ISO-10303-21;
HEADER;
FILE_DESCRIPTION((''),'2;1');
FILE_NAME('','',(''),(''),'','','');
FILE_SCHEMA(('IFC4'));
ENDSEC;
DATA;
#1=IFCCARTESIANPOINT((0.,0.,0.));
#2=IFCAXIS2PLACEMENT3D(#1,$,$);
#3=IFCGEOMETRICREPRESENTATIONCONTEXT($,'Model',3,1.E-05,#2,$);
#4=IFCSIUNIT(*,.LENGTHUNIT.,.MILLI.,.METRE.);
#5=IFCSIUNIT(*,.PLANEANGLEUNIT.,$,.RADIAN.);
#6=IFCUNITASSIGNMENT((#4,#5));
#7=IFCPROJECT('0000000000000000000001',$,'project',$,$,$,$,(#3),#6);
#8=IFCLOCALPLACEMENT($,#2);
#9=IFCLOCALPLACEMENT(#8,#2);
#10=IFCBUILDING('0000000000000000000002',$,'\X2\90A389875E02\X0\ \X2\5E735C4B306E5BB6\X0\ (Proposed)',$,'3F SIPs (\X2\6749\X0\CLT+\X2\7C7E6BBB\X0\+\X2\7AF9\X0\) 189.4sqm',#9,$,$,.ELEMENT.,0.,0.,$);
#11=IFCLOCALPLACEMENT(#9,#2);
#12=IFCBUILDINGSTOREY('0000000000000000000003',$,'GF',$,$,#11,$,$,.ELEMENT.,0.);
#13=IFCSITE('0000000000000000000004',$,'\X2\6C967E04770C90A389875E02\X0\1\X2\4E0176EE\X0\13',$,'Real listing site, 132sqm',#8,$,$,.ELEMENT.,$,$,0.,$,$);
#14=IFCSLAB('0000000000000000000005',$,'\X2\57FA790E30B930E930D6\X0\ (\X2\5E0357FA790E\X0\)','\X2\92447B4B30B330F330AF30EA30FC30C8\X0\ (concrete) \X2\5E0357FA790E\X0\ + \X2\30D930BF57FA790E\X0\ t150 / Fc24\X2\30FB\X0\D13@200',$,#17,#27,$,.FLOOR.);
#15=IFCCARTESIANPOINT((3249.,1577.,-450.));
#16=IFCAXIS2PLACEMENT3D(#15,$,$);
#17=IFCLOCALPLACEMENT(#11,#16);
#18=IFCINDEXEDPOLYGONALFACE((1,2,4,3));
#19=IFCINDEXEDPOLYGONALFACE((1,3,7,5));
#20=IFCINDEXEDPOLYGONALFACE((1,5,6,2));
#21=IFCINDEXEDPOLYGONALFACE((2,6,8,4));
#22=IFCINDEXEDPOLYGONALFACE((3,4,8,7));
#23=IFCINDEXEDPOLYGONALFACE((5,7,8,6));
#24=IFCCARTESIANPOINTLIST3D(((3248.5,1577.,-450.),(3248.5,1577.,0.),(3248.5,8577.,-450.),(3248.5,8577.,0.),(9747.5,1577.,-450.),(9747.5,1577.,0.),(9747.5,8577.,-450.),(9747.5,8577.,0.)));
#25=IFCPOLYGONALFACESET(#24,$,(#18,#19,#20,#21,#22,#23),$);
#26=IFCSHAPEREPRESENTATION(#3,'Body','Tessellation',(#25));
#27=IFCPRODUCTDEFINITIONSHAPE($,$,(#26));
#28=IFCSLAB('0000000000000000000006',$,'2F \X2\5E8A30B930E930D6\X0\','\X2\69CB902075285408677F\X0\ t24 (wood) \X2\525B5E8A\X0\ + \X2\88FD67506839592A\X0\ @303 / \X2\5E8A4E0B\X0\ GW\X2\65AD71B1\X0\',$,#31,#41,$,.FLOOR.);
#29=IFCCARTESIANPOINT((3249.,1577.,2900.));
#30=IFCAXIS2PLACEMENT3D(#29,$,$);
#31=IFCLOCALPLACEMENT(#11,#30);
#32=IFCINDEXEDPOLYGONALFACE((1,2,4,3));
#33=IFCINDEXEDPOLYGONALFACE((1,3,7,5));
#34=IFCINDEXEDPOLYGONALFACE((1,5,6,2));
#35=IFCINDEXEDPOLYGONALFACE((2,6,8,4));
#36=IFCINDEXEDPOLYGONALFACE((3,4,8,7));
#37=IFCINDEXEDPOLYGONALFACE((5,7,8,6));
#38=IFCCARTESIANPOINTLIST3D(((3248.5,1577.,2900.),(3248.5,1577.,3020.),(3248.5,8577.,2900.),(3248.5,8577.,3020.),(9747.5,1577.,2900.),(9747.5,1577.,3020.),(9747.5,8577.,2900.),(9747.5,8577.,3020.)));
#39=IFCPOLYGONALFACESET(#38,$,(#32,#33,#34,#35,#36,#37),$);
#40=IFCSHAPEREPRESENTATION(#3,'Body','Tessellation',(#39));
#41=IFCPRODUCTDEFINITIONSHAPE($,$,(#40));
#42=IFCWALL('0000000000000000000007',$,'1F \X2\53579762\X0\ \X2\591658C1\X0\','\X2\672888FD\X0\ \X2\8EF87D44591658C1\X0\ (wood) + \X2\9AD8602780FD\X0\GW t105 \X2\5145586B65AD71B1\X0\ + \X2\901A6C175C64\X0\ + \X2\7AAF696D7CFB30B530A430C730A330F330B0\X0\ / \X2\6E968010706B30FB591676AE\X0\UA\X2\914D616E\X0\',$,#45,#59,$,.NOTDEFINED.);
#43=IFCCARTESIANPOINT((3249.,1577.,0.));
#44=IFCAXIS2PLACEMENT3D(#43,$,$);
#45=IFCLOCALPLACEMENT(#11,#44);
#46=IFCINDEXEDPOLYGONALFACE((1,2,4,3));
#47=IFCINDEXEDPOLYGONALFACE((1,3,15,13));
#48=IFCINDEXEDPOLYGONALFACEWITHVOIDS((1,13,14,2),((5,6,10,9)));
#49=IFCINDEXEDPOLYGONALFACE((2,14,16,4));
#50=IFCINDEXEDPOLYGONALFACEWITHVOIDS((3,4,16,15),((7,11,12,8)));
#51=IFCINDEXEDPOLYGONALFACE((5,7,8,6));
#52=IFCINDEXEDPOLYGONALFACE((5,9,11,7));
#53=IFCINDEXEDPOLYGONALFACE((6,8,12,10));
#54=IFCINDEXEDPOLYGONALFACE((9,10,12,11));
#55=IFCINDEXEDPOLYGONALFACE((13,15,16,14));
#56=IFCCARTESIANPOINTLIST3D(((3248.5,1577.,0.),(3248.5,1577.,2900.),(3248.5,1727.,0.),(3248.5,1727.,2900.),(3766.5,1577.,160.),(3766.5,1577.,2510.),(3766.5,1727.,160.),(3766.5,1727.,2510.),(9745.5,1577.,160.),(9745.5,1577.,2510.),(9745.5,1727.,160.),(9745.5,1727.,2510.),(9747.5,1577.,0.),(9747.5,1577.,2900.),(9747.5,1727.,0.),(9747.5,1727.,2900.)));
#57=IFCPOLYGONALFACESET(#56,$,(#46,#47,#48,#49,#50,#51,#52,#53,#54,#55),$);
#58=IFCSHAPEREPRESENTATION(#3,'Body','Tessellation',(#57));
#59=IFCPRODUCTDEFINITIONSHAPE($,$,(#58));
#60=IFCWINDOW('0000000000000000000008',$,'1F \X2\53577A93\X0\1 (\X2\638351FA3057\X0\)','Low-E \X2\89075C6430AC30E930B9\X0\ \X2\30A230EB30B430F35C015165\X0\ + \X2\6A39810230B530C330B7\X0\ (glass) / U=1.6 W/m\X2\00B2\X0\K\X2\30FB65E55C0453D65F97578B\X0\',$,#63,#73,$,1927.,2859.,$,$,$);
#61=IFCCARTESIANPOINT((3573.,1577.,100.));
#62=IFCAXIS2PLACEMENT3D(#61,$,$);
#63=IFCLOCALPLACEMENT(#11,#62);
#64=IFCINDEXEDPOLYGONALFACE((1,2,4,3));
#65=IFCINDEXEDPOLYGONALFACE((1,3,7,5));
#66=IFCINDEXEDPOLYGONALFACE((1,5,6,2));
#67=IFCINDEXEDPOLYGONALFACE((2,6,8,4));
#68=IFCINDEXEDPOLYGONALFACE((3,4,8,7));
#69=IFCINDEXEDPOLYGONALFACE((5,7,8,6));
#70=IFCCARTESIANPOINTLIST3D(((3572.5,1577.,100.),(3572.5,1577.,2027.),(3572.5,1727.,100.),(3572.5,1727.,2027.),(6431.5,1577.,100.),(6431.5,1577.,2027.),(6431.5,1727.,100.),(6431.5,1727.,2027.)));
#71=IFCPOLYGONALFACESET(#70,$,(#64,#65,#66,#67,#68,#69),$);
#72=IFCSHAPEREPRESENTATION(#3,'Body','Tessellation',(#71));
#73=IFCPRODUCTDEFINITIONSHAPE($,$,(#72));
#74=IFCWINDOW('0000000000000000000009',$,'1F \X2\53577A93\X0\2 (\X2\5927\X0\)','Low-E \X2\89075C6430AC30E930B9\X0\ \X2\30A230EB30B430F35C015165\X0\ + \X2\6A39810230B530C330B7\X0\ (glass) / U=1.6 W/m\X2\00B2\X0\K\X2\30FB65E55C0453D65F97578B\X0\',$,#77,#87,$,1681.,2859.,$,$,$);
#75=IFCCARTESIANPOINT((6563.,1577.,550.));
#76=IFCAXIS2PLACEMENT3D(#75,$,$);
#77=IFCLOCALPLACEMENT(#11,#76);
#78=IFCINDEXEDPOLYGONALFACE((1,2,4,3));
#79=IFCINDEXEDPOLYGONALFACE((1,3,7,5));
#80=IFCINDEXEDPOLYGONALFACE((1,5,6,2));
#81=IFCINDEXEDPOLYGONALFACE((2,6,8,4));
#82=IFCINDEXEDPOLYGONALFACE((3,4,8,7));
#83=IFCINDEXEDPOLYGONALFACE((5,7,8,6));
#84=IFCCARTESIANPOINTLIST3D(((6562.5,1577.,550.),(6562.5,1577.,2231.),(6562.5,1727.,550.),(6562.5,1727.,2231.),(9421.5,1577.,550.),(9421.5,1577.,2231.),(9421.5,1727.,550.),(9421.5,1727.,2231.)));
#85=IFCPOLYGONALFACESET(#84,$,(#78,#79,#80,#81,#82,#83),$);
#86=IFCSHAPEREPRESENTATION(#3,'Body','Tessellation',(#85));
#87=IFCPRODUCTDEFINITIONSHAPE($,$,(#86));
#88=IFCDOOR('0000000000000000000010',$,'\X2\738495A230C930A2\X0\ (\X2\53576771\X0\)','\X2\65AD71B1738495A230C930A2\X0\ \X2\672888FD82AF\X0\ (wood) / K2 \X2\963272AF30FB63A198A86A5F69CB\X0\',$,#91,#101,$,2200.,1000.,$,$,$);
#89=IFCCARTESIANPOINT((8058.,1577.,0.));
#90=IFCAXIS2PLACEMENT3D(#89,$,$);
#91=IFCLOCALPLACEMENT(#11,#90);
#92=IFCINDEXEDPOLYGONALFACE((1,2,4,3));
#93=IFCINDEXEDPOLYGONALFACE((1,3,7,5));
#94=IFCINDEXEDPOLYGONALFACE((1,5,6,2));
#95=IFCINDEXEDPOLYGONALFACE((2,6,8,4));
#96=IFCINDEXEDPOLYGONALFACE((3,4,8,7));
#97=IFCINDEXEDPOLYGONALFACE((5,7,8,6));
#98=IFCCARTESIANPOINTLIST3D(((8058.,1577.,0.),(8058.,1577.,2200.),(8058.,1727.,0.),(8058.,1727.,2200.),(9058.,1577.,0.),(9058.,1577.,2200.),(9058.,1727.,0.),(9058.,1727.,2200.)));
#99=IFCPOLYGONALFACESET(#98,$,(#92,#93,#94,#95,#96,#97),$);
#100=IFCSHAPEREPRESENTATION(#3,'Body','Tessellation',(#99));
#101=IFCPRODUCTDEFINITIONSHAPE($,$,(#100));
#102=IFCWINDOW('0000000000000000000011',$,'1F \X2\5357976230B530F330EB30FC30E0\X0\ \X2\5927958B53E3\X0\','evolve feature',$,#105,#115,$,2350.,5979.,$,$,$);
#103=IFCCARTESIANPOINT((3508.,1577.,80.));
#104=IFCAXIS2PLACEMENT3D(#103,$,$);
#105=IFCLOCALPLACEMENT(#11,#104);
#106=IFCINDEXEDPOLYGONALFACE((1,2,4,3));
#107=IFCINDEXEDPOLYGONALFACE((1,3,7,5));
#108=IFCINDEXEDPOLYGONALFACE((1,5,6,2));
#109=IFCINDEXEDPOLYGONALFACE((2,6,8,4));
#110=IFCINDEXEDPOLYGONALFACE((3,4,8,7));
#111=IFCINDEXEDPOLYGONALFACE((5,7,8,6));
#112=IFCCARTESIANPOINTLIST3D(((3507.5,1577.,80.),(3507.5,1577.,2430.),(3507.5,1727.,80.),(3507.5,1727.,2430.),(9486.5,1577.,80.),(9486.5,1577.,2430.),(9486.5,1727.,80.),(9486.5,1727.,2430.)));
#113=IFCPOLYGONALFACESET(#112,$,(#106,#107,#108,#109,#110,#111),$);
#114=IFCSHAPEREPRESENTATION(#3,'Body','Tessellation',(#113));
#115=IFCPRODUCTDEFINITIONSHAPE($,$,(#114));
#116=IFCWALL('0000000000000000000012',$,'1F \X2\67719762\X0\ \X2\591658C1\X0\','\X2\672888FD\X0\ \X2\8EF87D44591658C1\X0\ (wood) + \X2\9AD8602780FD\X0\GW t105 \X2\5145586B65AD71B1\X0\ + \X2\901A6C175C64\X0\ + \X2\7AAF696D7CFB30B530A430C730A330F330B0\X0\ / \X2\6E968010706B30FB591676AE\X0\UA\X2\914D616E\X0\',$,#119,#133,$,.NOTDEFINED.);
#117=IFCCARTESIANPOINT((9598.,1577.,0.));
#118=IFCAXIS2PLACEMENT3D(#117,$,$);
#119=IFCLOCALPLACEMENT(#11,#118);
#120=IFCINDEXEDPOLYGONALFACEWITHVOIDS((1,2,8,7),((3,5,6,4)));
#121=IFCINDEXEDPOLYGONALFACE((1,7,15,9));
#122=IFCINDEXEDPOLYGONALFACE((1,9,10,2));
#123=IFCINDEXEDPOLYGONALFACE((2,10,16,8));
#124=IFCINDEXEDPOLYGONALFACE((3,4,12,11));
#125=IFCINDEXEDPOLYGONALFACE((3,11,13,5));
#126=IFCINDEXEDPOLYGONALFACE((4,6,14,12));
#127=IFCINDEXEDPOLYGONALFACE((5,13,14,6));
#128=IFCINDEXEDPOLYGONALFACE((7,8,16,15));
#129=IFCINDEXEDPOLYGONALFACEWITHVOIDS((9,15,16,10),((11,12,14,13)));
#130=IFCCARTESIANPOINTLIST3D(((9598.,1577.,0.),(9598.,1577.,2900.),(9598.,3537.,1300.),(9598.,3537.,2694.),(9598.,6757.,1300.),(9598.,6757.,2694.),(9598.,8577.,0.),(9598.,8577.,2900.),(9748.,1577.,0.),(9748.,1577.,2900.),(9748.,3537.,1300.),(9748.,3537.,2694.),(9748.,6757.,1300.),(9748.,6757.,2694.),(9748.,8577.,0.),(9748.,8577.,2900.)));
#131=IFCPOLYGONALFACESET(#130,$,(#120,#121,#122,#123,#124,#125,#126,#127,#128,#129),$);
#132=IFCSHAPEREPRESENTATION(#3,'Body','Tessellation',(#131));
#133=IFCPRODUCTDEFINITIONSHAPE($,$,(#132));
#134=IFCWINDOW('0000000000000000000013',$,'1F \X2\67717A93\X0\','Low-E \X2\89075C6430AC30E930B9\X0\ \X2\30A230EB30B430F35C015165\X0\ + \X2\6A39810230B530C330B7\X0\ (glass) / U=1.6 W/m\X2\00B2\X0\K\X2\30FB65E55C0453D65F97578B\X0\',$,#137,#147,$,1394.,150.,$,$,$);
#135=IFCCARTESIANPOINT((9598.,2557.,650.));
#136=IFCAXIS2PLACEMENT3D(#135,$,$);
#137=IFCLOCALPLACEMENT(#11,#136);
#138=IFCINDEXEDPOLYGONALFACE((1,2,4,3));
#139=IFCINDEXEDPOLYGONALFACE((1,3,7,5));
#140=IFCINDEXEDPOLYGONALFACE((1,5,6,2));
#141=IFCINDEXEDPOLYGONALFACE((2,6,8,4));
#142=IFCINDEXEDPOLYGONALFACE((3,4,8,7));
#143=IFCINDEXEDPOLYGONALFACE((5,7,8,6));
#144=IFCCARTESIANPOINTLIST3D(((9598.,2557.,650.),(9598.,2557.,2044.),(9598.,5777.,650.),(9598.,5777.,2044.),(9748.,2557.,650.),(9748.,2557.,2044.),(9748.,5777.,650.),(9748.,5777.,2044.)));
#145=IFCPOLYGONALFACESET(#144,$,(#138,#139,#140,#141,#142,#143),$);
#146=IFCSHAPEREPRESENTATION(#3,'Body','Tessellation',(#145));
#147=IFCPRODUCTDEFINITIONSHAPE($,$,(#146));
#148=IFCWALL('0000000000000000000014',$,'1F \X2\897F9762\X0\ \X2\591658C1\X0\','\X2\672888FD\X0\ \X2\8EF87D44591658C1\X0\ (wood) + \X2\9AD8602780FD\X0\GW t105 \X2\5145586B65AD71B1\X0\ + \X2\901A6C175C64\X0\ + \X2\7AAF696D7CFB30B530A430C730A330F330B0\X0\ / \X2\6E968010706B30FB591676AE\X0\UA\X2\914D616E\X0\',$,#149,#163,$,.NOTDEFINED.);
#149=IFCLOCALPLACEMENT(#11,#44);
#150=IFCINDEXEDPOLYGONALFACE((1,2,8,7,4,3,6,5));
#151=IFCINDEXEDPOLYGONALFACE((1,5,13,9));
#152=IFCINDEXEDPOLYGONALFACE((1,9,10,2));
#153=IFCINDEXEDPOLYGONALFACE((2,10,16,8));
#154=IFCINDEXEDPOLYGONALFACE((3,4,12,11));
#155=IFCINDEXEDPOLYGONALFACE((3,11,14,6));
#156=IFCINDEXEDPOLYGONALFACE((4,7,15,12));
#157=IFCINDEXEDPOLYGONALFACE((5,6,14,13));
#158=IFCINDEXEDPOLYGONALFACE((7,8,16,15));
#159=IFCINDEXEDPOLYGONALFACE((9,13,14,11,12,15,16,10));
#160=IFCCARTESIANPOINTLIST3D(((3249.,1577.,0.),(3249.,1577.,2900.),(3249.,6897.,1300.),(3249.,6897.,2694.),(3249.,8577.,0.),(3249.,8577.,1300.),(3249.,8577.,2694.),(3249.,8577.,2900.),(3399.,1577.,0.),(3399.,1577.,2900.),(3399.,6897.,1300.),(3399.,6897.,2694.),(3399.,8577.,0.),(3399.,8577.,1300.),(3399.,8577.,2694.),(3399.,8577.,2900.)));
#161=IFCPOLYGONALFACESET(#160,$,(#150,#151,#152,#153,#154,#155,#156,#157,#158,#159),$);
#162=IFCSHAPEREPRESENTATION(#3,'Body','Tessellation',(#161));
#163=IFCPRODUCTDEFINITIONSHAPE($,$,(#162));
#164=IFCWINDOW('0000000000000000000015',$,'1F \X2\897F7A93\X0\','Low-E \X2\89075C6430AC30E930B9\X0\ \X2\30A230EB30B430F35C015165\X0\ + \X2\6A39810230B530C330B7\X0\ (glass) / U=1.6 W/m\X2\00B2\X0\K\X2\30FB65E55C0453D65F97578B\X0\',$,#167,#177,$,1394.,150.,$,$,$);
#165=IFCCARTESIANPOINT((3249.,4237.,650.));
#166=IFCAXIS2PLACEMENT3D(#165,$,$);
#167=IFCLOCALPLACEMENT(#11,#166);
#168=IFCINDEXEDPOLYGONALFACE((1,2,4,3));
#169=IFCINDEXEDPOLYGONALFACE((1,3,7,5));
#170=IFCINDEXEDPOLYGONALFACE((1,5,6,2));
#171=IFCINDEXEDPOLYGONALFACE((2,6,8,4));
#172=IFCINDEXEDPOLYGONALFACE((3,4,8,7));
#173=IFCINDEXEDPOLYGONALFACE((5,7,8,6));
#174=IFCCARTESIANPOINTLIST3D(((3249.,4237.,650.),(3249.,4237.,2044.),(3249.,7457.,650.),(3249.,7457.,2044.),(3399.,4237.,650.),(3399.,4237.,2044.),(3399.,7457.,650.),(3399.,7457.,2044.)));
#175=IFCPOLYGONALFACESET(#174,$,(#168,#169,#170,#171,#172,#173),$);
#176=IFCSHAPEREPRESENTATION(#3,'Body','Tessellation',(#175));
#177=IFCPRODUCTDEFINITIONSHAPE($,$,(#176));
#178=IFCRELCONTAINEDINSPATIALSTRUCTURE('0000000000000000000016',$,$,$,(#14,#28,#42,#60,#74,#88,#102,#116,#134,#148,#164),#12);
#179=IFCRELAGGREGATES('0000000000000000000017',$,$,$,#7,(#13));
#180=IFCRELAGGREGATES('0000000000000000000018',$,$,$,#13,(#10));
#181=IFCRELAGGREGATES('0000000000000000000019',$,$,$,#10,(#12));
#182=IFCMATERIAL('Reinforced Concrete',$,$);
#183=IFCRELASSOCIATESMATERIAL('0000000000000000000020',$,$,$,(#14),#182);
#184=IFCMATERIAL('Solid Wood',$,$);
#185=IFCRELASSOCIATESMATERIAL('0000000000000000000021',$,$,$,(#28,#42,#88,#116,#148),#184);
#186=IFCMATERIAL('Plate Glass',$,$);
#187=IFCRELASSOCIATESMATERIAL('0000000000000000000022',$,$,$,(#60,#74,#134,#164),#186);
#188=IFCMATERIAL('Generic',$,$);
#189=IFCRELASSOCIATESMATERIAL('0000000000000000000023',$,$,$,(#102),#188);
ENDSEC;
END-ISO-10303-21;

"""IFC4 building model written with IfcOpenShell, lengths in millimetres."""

from ifc_helpers import new_model, si_unit, frame, frame_2d, origin, place, context, project, spatial, rectangle, extrude, material, element, fill, save


model = new_model("IFC4")

# Units and contexts
model_context = context("Model", 3, precision=1e-05, world=origin())
ifc_project = project(units=[si_unit("LENGTHUNIT", "METRE", prefix="MILLI"), si_unit("PLANEANGLEUNIT", "RADIAN")], contexts=[model_context])

# Site, building, storey
site_placement = place(None, origin())
site = spatial("IfcSite", under=ifc_project, at=site_placement, Name="沖縄県那覇市1丁目13", ObjectType="Real listing site, 132sqm", CompositionType="ELEMENT", RefElevation=0.0)
building_placement = place(site_placement, origin())
building = spatial("IfcBuilding", under=site, at=building_placement, Name="那覇市 平屋の家 (Proposed)", ObjectType="3F SIPs (杉CLT+籾殻+竹) 189.4sqm", CompositionType="ELEMENT", ElevationOfRefHeight=0.0, ElevationOfTerrain=0.0)
storey_placement = place(building_placement, origin())
storey = spatial("IfcBuildingStorey", under=building, at=storey_placement, Name="GF", CompositionType="ELEMENT", Elevation=0.0)

# Slabs
ifc_material_1 = material(Name="Reinforced Concrete")
slab_1_placement = place(storey_placement, frame((3249.0, 1577.0, -450.0)))
element("IfcSlab", 1, at=slab_1_placement, inside=storey, material=ifc_material_1, Name="基礎スラブ (布基礎)", Description="鉄筋コンクリート (concrete) 布基礎 + ベタ基礎 t150 / Fc24・D13@200", PredefinedType="FLOOR", context=model_context, shape_type="SweptSolid", body=[
    extrude(rectangle(XDim=6499.0, YDim=7000.0, at=frame_2d((3249.0, 3500.0))), frame((3249.0, 1577.0, -450.0)), (0.0, 0.0, 1.0), 450.0),
])
ifc_material_2 = material(Name="Solid Wood")
slab_2_placement = place(storey_placement, frame((3249.0, 1577.0, 2900.0)))
element("IfcSlab", 2, at=slab_2_placement, inside=storey, material=ifc_material_2, Name="2F 床スラブ", Description="構造用合板 t24 (wood) 剛床 + 製材根太 @303 / 床下 GW断熱", PredefinedType="FLOOR", context=model_context, shape_type="SweptSolid", body=[
    extrude(rectangle(XDim=6499.0, YDim=7000.0, at=frame_2d((3249.0, 3500.0))), frame((3249.0, 1577.0, 2900.0)), (0.0, 0.0, 1.0), 120.0),
])

# Wall, openings, windows, door
wall_1_placement = place(storey_placement, frame((3249.0, 1577.0, 0.0)))
wall_1 = element("IfcWall", 3, at=wall_1_placement, inside=storey, material=ifc_material_2, Name="1F 南面 外壁", Description="木製 軸組外壁 (wood) + 高性能GW t105 充填断熱 + 通気層 + 窯業系サイディング / 準耐火・外皮UA配慮", PredefinedType="NOTDEFINED", context=model_context, shape_type="SweptSolid", body=[
    extrude(rectangle(XDim=6499.0, YDim=150.0, at=frame_2d((3249.0, 75.0))), frame((3249.0, 1577.0, 0.0)), (0.0, 0.0, 1.0), 2900.0),
])
opening_1_placement = place(storey_placement, frame((3573.0, 1577.0, 100.0)))
opening_1 = element("IfcOpeningElement", 4, at=opening_1_placement, cuts=wall_1, PredefinedType="NOTDEFINED", context=model_context, shape_type="SweptSolid", body=[
    extrude(rectangle(XDim=2859.0, YDim=150.0, at=frame_2d((1429.0, 75.0))), frame((3573.0, 1577.0, 100.0)), (0.0, 0.0, 1.0), 1927.0),
])
opening_2_placement = place(storey_placement, frame((6563.0, 1577.0, 550.0)))
opening_2 = element("IfcOpeningElement", 5, at=opening_2_placement, cuts=wall_1, PredefinedType="NOTDEFINED", context=model_context, shape_type="SweptSolid", body=[
    extrude(rectangle(XDim=2859.0, YDim=150.0, at=frame_2d((1429.0, 75.0))), frame((6563.0, 1577.0, 550.0)), (0.0, 0.0, 1.0), 1681.0),
])
opening_3_placement = place(storey_placement, frame((8058.0, 1577.0, 0.0)))
opening_3 = element("IfcOpeningElement", 6, at=opening_3_placement, cuts=wall_1, PredefinedType="NOTDEFINED", context=model_context, shape_type="SweptSolid", body=[
    extrude(rectangle(XDim=1000.0, YDim=150.0, at=frame_2d((500.0, 75.0))), frame((8058.0, 1577.0, 0.0)), (0.0, 0.0, 1.0), 2200.0),
])
opening_4_placement = place(storey_placement, frame((3508.0, 1577.0, 80.0)))
opening_4 = element("IfcOpeningElement", 7, at=opening_4_placement, cuts=wall_1, PredefinedType="NOTDEFINED", context=model_context, shape_type="SweptSolid", body=[
    extrude(rectangle(XDim=5979.0, YDim=150.0, at=frame_2d((2989.0, 75.0))), frame((3508.0, 1577.0, 80.0)), (0.0, 0.0, 1.0), 2350.0),
])
ifc_material_3 = material(Name="Plate Glass")
window_1_placement = place(storey_placement, frame((3573.0, 1577.0, 100.0)))
window_1 = element("IfcWindow", 8, at=window_1_placement, inside=storey, material=ifc_material_3, Name="1F 南窓1 (掃出し)", Description="Low-E 複層ガラス アルゴン封入 + 樹脂サッシ (glass) / U=1.6 W/m²K・日射取得型", OverallHeight=1927.0, OverallWidth=2859.0, context=model_context, shape_type="SweptSolid", body=[
    extrude(rectangle(XDim=2859.0, YDim=150.0, at=frame_2d((1429.0, 75.0))), frame((3573.0, 1577.0, 100.0)), (0.0, 0.0, 1.0), 1927.0),
])
fill(opening_1, window_1)
window_2_placement = place(storey_placement, frame((6563.0, 1577.0, 550.0)))
window_2 = element("IfcWindow", 9, at=window_2_placement, inside=storey, material=ifc_material_3, Name="1F 南窓2 (大)", Description="Low-E 複層ガラス アルゴン封入 + 樹脂サッシ (glass) / U=1.6 W/m²K・日射取得型", OverallHeight=1681.0, OverallWidth=2859.0, context=model_context, shape_type="SweptSolid", body=[
    extrude(rectangle(XDim=2859.0, YDim=150.0, at=frame_2d((1429.0, 75.0))), frame((6563.0, 1577.0, 550.0)), (0.0, 0.0, 1.0), 1681.0),
])
fill(opening_2, window_2)
door_placement = place(storey_placement, frame((8058.0, 1577.0, 0.0)))
door = element("IfcDoor", 10, at=door_placement, inside=storey, material=ifc_material_2, Name="玄関ドア (南東)", Description="断熱玄関ドア 木製芯 (wood) / K2 防犯・採風機構", OverallHeight=2200.0, OverallWidth=1000.0, context=model_context, shape_type="SweptSolid", body=[
    extrude(rectangle(XDim=1000.0, YDim=150.0, at=frame_2d((500.0, 75.0))), frame((8058.0, 1577.0, 0.0)), (0.0, 0.0, 1.0), 2200.0),
])
fill(opening_3, door)
ifc_material_4 = material(Name="Generic")
window_3_placement = place(storey_placement, frame((3508.0, 1577.0, 80.0)))
window_3 = element("IfcWindow", 11, at=window_3_placement, inside=storey, material=ifc_material_4, Name="1F 南面サンルーム 大開口", Description="evolve feature", OverallHeight=2350.0, OverallWidth=5979.0, context=model_context, shape_type="SweptSolid", body=[
    extrude(rectangle(XDim=5979.0, YDim=150.0, at=frame_2d((2989.0, 75.0))), frame((3508.0, 1577.0, 80.0)), (0.0, 0.0, 1.0), 2350.0),
])
fill(opening_4, window_3)

# Walls, openings, windows
wall_2_placement = place(storey_placement, frame((9598.0, 1577.0, 0.0)))
wall_2 = element("IfcWall", 12, at=wall_2_placement, inside=storey, material=ifc_material_2, Name="1F 東面 外壁", Description="木製 軸組外壁 (wood) + 高性能GW t105 充填断熱 + 通気層 + 窯業系サイディング / 準耐火・外皮UA配慮", PredefinedType="NOTDEFINED", context=model_context, shape_type="SweptSolid", body=[
    extrude(rectangle(XDim=150.0, YDim=7000.0, at=frame_2d((75.0, 3500.0))), frame((9598.0, 1577.0, 0.0)), (0.0, 0.0, 1.0), 2900.0),
])
opening_5_placement = place(storey_placement, frame((9598.0, 2557.0, 650.0)))
opening_5 = element("IfcOpeningElement", 13, at=opening_5_placement, cuts=wall_2, PredefinedType="NOTDEFINED", context=model_context, shape_type="SweptSolid", body=[
    extrude(rectangle(XDim=150.0, YDim=3220.0, at=frame_2d((75.0, 1610.0))), frame((9598.0, 2557.0, 650.0)), (0.0, 0.0, 1.0), 1394.0),
])
window_4_placement = place(storey_placement, frame((9598.0, 2557.0, 650.0)))
window_4 = element("IfcWindow", 14, at=window_4_placement, inside=storey, material=ifc_material_3, Name="1F 東窓", Description="Low-E 複層ガラス アルゴン封入 + 樹脂サッシ (glass) / U=1.6 W/m²K・日射取得型", OverallHeight=1394.0, OverallWidth=150.0, context=model_context, shape_type="SweptSolid", body=[
    extrude(rectangle(XDim=150.0, YDim=3220.0, at=frame_2d((75.0, 1610.0))), frame((9598.0, 2557.0, 650.0)), (0.0, 0.0, 1.0), 1394.0),
])
fill(opening_5, window_4)
wall_3_placement = place(storey_placement, frame((3249.0, 1577.0, 0.0)))
wall_3 = element("IfcWall", 15, at=wall_3_placement, inside=storey, material=ifc_material_2, Name="1F 西面 外壁", Description="木製 軸組外壁 (wood) + 高性能GW t105 充填断熱 + 通気層 + 窯業系サイディング / 準耐火・外皮UA配慮", PredefinedType="NOTDEFINED", context=model_context, shape_type="SweptSolid", body=[
    extrude(rectangle(XDim=150.0, YDim=7000.0, at=frame_2d((75.0, 3500.0))), frame((3249.0, 1577.0, 0.0)), (0.0, 0.0, 1.0), 2900.0),
])
opening_6_placement = place(storey_placement, frame((3249.0, 4237.0, 650.0)))
opening_6 = element("IfcOpeningElement", 16, at=opening_6_placement, cuts=wall_3, PredefinedType="NOTDEFINED", context=model_context, shape_type="SweptSolid", body=[
    extrude(rectangle(XDim=150.0, YDim=3220.0, at=frame_2d((75.0, 1610.0))), frame((3249.0, 4237.0, 650.0)), (0.0, 0.0, 1.0), 1394.0),
])
window_5_placement = place(storey_placement, frame((3249.0, 4237.0, 650.0)))
window_5 = element("IfcWindow", 17, at=window_5_placement, inside=storey, material=ifc_material_3, Name="1F 西窓", Description="Low-E 複層ガラス アルゴン封入 + 樹脂サッシ (glass) / U=1.6 W/m²K・日射取得型", OverallHeight=1394.0, OverallWidth=150.0, context=model_context, shape_type="SweptSolid", body=[
    extrude(rectangle(XDim=150.0, YDim=3220.0, at=frame_2d((75.0, 1610.0))), frame((3249.0, 4237.0, 650.0)), (0.0, 0.0, 1.0), 1394.0),
])
fill(opening_6, window_5)

save(model, "model.ifc")
